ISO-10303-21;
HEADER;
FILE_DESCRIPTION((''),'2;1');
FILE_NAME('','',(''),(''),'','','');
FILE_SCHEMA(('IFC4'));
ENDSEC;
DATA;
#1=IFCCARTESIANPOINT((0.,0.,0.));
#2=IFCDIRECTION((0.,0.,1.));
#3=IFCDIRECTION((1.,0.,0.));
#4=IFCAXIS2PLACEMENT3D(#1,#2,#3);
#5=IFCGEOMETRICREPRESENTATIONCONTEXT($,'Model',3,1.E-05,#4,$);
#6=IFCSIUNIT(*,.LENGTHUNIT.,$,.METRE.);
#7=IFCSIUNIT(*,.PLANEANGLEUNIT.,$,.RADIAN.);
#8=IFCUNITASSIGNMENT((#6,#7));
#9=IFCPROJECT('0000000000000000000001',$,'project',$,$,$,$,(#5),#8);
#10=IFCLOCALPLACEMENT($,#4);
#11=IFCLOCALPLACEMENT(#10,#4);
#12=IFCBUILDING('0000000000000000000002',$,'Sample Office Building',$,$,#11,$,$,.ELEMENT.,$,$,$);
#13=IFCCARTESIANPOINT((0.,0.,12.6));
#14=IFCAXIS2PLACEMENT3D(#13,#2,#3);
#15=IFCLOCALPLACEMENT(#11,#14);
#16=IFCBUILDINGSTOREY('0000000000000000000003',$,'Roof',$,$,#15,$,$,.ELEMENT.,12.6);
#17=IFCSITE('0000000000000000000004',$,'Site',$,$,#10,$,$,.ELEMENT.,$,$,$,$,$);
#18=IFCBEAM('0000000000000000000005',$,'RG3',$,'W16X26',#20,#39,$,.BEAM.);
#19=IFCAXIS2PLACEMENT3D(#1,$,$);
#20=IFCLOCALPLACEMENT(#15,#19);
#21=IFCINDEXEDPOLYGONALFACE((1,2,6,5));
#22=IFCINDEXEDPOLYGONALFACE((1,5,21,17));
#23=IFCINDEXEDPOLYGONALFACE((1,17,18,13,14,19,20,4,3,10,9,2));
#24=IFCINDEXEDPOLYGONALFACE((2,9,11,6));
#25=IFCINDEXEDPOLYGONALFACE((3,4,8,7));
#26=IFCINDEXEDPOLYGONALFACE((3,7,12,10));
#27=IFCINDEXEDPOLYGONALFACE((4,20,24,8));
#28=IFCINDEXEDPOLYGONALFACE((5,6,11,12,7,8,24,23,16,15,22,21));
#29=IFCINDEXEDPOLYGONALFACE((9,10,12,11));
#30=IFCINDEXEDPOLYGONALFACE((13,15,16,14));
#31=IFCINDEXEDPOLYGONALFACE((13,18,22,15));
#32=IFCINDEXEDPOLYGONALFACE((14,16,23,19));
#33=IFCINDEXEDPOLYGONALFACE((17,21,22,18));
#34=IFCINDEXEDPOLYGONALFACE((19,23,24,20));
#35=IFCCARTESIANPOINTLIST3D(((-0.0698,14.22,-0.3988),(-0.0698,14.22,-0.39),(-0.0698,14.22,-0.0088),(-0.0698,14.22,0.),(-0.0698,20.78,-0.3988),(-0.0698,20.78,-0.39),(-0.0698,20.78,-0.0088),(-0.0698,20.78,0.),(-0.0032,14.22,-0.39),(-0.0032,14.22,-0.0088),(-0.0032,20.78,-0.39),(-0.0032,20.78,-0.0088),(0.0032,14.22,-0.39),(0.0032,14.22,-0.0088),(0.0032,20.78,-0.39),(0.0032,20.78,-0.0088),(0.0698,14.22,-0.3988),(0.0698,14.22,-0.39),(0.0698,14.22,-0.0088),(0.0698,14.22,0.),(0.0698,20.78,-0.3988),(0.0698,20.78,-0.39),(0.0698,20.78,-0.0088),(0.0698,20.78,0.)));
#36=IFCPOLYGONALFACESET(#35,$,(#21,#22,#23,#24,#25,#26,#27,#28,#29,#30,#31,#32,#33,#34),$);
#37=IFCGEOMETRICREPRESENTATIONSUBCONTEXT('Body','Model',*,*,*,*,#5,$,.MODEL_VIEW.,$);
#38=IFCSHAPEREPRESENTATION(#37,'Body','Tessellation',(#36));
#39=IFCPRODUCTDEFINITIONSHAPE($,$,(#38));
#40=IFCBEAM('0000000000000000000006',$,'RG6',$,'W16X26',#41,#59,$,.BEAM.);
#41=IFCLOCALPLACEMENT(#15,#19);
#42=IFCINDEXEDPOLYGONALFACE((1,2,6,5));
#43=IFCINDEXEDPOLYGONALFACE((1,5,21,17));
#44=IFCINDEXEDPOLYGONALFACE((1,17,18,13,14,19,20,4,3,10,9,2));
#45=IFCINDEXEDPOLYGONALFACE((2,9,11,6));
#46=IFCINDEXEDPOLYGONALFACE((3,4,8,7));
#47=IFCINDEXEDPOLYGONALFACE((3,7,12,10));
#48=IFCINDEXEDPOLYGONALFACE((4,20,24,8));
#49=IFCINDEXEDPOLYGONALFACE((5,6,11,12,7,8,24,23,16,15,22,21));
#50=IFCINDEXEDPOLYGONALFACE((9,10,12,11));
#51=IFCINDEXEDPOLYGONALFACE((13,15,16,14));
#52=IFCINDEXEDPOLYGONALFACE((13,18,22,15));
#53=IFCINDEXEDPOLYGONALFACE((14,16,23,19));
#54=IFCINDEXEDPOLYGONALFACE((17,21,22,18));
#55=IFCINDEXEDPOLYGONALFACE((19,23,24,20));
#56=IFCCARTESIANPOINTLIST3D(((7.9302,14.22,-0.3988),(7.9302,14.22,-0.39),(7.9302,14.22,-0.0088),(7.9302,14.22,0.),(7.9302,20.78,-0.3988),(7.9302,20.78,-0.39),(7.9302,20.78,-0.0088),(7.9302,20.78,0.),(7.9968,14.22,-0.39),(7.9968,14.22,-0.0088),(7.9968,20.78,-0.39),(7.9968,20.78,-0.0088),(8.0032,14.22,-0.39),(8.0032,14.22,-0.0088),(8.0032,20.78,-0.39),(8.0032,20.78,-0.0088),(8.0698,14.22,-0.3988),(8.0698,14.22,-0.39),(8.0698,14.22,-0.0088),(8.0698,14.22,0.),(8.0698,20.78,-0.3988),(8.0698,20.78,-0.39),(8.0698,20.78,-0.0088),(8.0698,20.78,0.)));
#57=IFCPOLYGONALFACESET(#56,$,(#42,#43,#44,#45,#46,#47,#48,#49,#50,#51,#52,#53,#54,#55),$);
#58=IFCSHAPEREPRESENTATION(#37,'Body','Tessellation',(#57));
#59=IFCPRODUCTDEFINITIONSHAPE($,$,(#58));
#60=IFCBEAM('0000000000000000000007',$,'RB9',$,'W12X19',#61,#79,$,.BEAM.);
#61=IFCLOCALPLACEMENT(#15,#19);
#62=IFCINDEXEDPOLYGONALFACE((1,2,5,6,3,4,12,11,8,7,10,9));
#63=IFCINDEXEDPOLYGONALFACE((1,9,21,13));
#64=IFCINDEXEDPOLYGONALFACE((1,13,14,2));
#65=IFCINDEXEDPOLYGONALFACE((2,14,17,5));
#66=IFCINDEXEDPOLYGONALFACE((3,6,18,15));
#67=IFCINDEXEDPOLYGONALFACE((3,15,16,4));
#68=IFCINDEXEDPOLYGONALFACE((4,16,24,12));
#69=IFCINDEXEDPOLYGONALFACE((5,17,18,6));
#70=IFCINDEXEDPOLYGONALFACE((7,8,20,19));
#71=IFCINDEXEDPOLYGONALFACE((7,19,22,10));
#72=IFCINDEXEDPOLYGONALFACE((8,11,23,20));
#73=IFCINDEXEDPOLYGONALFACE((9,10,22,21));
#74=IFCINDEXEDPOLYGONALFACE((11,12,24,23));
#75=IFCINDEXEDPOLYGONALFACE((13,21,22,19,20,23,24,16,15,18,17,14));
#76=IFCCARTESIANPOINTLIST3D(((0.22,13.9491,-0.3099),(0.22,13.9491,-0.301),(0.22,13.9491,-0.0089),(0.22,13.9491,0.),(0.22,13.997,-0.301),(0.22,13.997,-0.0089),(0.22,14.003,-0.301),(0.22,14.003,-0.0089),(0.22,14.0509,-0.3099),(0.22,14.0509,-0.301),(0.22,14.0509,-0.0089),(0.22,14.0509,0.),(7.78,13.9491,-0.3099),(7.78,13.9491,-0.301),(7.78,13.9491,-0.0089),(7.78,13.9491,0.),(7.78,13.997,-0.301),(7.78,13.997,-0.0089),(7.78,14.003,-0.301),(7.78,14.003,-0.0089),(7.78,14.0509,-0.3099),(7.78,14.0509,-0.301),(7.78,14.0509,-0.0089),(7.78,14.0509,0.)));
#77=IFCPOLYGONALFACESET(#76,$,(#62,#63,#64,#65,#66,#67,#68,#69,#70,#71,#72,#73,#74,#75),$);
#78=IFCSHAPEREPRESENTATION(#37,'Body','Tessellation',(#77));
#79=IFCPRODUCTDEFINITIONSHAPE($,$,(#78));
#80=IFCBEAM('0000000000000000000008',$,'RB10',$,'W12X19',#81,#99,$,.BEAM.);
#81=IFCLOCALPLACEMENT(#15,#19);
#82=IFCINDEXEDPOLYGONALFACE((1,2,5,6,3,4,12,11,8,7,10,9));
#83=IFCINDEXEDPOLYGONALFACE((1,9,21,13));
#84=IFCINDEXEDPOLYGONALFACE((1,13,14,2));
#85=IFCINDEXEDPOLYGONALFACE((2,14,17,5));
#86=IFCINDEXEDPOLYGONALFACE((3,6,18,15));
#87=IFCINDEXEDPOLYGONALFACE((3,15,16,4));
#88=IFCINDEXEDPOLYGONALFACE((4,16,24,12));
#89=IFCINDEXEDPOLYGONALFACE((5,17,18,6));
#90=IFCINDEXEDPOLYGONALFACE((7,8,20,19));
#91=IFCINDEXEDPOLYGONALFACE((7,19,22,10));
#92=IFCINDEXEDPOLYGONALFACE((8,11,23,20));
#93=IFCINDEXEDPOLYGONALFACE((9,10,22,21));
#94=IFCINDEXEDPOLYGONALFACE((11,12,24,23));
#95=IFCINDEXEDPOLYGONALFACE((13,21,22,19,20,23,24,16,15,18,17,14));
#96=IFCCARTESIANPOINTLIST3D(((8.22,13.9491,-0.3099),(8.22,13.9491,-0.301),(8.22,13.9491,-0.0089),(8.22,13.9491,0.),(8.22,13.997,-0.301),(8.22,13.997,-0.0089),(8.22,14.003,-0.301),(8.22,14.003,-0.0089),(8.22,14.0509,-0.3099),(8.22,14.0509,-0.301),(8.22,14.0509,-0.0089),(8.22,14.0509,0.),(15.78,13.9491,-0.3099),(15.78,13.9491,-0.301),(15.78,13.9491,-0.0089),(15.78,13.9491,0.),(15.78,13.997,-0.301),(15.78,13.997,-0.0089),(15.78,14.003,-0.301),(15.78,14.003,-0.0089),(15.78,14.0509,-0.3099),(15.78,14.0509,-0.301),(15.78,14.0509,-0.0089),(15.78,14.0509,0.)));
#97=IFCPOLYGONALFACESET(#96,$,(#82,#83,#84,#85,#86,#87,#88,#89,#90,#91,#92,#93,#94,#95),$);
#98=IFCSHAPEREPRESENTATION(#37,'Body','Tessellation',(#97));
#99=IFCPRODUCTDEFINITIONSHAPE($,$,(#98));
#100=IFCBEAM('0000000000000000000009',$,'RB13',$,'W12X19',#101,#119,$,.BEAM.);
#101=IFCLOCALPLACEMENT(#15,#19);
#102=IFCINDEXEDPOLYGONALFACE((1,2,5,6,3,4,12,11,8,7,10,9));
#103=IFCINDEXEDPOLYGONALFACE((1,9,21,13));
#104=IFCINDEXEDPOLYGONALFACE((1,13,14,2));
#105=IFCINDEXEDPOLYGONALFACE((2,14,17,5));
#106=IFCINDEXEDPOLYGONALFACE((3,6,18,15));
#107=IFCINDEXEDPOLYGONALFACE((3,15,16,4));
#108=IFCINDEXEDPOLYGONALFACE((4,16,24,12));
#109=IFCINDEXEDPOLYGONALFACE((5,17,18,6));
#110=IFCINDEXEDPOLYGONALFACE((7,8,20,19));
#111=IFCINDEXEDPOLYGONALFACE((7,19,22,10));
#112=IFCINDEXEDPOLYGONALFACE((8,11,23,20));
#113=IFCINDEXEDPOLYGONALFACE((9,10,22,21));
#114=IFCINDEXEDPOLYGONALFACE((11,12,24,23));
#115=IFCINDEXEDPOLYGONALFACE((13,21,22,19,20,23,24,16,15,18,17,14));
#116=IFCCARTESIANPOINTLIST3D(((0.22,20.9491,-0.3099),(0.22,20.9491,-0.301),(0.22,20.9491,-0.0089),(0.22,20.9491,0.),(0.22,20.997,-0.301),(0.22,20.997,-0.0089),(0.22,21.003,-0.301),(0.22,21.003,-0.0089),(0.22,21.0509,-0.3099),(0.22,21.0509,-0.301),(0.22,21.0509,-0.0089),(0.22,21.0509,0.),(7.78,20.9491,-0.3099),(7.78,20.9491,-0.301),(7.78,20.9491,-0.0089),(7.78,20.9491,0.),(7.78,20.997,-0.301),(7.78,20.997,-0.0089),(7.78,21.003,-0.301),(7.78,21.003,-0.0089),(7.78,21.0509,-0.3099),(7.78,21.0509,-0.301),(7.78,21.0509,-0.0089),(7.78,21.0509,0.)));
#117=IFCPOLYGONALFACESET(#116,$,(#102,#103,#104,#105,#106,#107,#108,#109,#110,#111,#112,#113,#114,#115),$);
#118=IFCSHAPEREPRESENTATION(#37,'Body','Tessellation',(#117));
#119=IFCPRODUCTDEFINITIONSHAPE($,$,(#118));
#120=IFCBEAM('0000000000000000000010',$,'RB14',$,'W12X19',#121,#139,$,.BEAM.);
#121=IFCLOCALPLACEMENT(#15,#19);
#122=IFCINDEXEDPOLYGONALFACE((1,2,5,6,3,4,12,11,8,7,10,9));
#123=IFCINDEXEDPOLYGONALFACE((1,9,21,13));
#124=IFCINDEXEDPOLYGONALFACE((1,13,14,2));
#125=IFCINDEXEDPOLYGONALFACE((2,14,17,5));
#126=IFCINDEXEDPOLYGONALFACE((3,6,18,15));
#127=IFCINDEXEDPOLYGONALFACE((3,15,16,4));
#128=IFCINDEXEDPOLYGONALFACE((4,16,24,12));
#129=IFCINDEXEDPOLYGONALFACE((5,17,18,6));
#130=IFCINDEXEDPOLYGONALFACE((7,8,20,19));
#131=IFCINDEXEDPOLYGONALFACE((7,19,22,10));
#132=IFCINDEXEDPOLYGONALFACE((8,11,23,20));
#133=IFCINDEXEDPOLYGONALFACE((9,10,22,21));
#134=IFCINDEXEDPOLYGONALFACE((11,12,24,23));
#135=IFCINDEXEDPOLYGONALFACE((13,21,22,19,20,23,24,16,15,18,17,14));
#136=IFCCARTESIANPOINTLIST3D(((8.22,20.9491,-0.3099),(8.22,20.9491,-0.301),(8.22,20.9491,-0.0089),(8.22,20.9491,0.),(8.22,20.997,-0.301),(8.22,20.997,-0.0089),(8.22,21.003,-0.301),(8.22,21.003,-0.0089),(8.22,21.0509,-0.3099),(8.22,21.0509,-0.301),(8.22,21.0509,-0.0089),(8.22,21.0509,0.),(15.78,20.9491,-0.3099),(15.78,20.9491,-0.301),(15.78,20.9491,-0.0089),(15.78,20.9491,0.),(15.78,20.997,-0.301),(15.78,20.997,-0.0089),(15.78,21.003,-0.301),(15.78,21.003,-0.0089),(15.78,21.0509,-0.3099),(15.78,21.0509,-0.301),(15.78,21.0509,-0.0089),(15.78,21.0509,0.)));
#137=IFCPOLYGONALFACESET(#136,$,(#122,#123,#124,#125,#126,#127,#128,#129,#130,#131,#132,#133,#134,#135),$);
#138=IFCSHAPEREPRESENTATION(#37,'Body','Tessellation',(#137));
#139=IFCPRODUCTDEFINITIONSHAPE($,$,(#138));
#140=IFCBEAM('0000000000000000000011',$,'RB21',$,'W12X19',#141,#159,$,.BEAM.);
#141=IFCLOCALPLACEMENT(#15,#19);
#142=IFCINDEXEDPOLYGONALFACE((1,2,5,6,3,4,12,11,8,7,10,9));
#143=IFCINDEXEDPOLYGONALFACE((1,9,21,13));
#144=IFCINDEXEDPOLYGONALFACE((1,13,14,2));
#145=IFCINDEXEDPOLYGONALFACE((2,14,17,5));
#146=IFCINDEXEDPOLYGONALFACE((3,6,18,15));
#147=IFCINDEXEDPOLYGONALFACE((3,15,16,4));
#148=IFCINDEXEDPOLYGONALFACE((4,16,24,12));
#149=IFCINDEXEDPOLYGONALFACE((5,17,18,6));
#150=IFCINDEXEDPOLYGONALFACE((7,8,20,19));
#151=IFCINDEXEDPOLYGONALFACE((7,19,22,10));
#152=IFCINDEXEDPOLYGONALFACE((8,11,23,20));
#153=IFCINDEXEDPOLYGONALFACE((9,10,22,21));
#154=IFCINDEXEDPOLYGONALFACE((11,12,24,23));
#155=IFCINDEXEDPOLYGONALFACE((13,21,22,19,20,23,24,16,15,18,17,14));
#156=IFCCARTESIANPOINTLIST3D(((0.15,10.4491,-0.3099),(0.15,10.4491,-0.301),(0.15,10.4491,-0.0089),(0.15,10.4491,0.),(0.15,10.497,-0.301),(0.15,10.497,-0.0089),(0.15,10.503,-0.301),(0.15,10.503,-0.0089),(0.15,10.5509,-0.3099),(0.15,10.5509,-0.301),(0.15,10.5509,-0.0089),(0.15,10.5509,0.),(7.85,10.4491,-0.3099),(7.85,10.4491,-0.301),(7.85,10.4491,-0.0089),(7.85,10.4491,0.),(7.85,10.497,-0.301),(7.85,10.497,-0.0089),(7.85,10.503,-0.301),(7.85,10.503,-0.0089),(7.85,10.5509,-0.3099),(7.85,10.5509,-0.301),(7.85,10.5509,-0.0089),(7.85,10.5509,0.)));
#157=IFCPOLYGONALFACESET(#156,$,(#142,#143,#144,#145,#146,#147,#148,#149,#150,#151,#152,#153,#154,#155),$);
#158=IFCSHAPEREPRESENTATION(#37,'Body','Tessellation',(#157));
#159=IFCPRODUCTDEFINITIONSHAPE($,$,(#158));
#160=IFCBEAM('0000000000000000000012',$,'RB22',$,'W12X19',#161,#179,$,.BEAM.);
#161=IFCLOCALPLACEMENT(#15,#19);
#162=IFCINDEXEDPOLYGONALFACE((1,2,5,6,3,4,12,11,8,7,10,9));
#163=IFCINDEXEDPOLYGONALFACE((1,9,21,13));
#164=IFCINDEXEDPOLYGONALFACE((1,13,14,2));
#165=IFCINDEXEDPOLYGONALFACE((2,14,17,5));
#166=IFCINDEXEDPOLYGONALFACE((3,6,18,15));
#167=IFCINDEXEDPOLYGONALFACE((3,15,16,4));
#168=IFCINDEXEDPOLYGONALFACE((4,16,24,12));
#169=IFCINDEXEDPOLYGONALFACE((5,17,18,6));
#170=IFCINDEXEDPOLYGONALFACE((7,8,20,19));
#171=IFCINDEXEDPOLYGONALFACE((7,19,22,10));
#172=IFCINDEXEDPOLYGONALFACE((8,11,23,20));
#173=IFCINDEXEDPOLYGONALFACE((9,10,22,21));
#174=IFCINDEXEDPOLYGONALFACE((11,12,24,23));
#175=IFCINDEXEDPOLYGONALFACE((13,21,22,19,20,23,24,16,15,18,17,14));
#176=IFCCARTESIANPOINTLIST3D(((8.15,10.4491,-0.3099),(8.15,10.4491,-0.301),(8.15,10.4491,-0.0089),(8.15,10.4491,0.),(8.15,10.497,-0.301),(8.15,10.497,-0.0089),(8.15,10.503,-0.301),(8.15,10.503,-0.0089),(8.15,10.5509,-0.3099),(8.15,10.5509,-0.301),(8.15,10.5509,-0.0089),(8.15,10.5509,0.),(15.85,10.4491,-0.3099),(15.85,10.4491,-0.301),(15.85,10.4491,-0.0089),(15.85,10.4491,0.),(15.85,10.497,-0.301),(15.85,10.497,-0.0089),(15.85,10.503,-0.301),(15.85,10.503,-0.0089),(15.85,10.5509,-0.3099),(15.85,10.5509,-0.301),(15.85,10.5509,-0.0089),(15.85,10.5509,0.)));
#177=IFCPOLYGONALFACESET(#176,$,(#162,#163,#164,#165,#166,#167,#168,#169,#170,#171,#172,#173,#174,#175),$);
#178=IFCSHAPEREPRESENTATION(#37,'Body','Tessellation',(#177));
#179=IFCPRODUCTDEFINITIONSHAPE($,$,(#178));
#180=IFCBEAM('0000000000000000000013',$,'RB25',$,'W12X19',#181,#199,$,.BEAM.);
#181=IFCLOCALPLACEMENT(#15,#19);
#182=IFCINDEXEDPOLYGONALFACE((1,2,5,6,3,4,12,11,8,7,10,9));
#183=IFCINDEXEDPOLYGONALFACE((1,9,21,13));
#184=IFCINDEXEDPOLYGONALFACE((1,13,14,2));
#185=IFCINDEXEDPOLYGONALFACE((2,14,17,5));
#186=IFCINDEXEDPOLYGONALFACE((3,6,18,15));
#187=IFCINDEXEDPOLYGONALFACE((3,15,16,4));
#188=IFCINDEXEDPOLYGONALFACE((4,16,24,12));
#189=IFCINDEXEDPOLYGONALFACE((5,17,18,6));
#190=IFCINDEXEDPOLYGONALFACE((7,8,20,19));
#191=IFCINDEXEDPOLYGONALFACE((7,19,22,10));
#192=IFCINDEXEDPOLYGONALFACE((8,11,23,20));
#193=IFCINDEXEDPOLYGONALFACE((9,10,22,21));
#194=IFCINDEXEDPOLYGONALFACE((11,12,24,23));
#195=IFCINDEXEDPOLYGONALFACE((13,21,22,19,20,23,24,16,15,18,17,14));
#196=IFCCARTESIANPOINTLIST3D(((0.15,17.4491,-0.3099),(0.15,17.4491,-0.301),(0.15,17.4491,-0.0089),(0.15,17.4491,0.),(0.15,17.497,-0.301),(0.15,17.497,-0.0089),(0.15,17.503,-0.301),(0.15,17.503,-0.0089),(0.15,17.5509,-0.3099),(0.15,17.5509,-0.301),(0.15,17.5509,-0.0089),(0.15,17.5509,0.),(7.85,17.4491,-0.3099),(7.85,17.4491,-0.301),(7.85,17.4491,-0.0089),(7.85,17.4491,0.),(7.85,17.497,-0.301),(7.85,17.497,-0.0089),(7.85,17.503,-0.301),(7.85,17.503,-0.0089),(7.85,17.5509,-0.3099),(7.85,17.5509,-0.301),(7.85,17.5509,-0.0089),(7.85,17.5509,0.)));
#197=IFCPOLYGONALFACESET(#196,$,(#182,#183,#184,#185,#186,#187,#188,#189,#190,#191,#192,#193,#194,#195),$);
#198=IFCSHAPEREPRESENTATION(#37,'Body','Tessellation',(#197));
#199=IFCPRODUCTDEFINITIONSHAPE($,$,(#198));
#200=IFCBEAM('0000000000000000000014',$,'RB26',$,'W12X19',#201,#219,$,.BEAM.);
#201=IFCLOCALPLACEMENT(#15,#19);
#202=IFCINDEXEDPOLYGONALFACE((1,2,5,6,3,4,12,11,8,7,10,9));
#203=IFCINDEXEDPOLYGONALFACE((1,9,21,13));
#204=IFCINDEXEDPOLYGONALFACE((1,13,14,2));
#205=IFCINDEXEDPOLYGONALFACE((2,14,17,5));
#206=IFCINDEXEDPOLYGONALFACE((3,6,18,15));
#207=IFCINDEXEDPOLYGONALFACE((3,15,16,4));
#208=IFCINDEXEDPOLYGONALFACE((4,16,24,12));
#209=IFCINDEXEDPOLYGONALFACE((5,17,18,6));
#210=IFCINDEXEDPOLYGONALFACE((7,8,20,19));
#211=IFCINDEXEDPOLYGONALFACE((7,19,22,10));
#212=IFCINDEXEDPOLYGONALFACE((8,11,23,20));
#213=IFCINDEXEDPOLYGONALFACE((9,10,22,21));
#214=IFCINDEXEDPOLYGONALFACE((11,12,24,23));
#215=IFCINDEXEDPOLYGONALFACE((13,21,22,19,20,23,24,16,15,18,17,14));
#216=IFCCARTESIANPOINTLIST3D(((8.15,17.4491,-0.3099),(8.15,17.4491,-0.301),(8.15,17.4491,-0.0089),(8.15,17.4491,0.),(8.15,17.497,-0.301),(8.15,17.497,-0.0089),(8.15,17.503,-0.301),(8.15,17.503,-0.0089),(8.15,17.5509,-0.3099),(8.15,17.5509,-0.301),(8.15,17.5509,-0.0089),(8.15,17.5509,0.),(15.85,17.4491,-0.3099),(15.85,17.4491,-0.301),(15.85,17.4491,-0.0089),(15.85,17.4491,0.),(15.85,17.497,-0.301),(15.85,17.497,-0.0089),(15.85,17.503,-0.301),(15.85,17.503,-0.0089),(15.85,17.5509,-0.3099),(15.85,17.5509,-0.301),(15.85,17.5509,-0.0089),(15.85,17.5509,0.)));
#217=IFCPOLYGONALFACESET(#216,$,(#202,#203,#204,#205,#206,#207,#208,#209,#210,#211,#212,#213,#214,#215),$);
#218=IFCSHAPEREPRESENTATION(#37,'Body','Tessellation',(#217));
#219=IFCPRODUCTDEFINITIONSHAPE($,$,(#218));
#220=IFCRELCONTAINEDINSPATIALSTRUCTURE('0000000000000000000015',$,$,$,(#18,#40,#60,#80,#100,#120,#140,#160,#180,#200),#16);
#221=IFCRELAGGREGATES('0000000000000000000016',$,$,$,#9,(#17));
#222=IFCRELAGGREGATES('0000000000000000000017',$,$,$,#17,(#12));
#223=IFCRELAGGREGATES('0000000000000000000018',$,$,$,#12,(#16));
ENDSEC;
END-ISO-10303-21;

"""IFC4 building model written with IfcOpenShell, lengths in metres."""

from ifc_helpers import new_model, si_unit, frame, origin_with_axes, place, context, subcontext, project, spatial, i_section, extrude, element, save


model = new_model("IFC4")

# Units and contexts
model_context = context("Model", 3, precision=1e-05, world=origin_with_axes())
body_context = subcontext(model_context, "Body", "Model", "MODEL_VIEW")
ifc_project = project(units=[si_unit("LENGTHUNIT", "METRE"), si_unit("PLANEANGLEUNIT", "RADIAN")], contexts=[model_context])

# Site, building, storey
site_placement = place(None, origin_with_axes())
site = spatial("IfcSite", under=ifc_project, at=site_placement, Name="Site", CompositionType="ELEMENT")
building_placement = place(site_placement, origin_with_axes())
building = spatial("IfcBuilding", under=site, at=building_placement, Name="Sample Office Building", CompositionType="ELEMENT")
storey_placement = place(building_placement, frame((0.0, 0.0, 12.6), z_axis=(0.0, 0.0, 1.0), x_axis=(1.0, 0.0, 0.0)))
storey = spatial("IfcBuildingStorey", under=building, at=storey_placement, Name="Roof", CompositionType="ELEMENT", Elevation=12.6)

# Beams
for number, where, z_axis, x_axis, name in (
    (1, (0.0, 14.22, 12.4006), (0.0, 1.0, 0.0), (-1.0, 0.0, 0.0), "RG3"),
    (2, (8.0, 14.22, 12.4006), (0.0, 1.0, 0.0), (-1.0, 0.0, 0.0), "RG6"),
):
    element("IfcBeam", number, at=place(None, frame(where, z_axis=z_axis, x_axis=x_axis)), inside=storey, Name=name, ObjectType="W16X26", PredefinedType="BEAM", context=body_context, shape_type="SweptSolid", body=[
        extrude(i_section(OverallWidth=0.1397, OverallDepth=0.3988, WebThickness=0.0063, FlangeThickness=0.0088), None, (0.0, 0.0, 1.0), 6.56),
    ])
beam_1_placement = place(None, frame((0.22, 14.0, 12.4451), z_axis=(1.0, 0.0, 0.0), x_axis=(0.0, 1.0, 0.0)))
element("IfcBeam", 3, at=beam_1_placement, inside=storey, Name="RB9", ObjectType="W12X19", PredefinedType="BEAM", context=body_context, shape_type="SweptSolid", body=[
    extrude(i_section(OverallWidth=0.1019, OverallDepth=0.3099, WebThickness=0.006, FlangeThickness=0.0089), None, (0.0, 0.0, 1.0), 7.56),
])
beam_2_placement = place(None, frame((8.22, 14.0, 12.4451), z_axis=(1.0, 0.0, 0.0), x_axis=(0.0, 1.0, 0.0)))
element("IfcBeam", 4, at=beam_2_placement, inside=storey, Name="RB10", ObjectType="W12X19", PredefinedType="BEAM", context=body_context, shape_type="SweptSolid", body=[
    extrude(i_section(OverallWidth=0.1019, OverallDepth=0.3099, WebThickness=0.006, FlangeThickness=0.0089), None, (0.0, 0.0, 1.0), 7.56),
])
beam_3_placement = place(None, frame((0.22, 21.0, 12.4451), z_axis=(1.0, 0.0, 0.0), x_axis=(0.0, 1.0, 0.0)))
element("IfcBeam", 5, at=beam_3_placement, inside=storey, Name="RB13", ObjectType="W12X19", PredefinedType="BEAM", context=body_context, shape_type="SweptSolid", body=[
    extrude(i_section(OverallWidth=0.1019, OverallDepth=0.3099, WebThickness=0.006, FlangeThickness=0.0089), None, (0.0, 0.0, 1.0), 7.56),
])
beam_4_placement = place(None, frame((8.22, 21.0, 12.4451), z_axis=(1.0, 0.0, 0.0), x_axis=(0.0, 1.0, 0.0)))
element("IfcBeam", 6, at=beam_4_placement, inside=storey, Name="RB14", ObjectType="W12X19", PredefinedType="BEAM", context=body_context, shape_type="SweptSolid", body=[
    extrude(i_section(OverallWidth=0.1019, OverallDepth=0.3099, WebThickness=0.006, FlangeThickness=0.0089), None, (0.0, 0.0, 1.0), 7.56),
])
for number, where, z_axis, x_axis, name in (
    (7, (0.15, 10.5, 12.4451), (1.0, 0.0, 0.0), (0.0, 1.0, 0.0), "RB21"),
    (8, (8.15, 10.5, 12.4451), (1.0, 0.0, 0.0), (0.0, 1.0, 0.0), "RB22"),
    (9, (0.15, 17.5, 12.4451), (1.0, 0.0, 0.0), (0.0, 1.0, 0.0), "RB25"),
    (10, (8.15, 17.5, 12.4451), (1.0, 0.0, 0.0), (0.0, 1.0, 0.0), "RB26"),
):
    element("IfcBeam", number, at=place(None, frame(where, z_axis=z_axis, x_axis=x_axis)), inside=storey, Name=name, ObjectType="W12X19", PredefinedType="BEAM", context=body_context, shape_type="SweptSolid", body=[
        extrude(i_section(OverallWidth=0.1019, OverallDepth=0.3099, WebThickness=0.006, FlangeThickness=0.0089), None, (0.0, 0.0, 1.0), 7.7),
    ])

save(model, "model.ifc")
